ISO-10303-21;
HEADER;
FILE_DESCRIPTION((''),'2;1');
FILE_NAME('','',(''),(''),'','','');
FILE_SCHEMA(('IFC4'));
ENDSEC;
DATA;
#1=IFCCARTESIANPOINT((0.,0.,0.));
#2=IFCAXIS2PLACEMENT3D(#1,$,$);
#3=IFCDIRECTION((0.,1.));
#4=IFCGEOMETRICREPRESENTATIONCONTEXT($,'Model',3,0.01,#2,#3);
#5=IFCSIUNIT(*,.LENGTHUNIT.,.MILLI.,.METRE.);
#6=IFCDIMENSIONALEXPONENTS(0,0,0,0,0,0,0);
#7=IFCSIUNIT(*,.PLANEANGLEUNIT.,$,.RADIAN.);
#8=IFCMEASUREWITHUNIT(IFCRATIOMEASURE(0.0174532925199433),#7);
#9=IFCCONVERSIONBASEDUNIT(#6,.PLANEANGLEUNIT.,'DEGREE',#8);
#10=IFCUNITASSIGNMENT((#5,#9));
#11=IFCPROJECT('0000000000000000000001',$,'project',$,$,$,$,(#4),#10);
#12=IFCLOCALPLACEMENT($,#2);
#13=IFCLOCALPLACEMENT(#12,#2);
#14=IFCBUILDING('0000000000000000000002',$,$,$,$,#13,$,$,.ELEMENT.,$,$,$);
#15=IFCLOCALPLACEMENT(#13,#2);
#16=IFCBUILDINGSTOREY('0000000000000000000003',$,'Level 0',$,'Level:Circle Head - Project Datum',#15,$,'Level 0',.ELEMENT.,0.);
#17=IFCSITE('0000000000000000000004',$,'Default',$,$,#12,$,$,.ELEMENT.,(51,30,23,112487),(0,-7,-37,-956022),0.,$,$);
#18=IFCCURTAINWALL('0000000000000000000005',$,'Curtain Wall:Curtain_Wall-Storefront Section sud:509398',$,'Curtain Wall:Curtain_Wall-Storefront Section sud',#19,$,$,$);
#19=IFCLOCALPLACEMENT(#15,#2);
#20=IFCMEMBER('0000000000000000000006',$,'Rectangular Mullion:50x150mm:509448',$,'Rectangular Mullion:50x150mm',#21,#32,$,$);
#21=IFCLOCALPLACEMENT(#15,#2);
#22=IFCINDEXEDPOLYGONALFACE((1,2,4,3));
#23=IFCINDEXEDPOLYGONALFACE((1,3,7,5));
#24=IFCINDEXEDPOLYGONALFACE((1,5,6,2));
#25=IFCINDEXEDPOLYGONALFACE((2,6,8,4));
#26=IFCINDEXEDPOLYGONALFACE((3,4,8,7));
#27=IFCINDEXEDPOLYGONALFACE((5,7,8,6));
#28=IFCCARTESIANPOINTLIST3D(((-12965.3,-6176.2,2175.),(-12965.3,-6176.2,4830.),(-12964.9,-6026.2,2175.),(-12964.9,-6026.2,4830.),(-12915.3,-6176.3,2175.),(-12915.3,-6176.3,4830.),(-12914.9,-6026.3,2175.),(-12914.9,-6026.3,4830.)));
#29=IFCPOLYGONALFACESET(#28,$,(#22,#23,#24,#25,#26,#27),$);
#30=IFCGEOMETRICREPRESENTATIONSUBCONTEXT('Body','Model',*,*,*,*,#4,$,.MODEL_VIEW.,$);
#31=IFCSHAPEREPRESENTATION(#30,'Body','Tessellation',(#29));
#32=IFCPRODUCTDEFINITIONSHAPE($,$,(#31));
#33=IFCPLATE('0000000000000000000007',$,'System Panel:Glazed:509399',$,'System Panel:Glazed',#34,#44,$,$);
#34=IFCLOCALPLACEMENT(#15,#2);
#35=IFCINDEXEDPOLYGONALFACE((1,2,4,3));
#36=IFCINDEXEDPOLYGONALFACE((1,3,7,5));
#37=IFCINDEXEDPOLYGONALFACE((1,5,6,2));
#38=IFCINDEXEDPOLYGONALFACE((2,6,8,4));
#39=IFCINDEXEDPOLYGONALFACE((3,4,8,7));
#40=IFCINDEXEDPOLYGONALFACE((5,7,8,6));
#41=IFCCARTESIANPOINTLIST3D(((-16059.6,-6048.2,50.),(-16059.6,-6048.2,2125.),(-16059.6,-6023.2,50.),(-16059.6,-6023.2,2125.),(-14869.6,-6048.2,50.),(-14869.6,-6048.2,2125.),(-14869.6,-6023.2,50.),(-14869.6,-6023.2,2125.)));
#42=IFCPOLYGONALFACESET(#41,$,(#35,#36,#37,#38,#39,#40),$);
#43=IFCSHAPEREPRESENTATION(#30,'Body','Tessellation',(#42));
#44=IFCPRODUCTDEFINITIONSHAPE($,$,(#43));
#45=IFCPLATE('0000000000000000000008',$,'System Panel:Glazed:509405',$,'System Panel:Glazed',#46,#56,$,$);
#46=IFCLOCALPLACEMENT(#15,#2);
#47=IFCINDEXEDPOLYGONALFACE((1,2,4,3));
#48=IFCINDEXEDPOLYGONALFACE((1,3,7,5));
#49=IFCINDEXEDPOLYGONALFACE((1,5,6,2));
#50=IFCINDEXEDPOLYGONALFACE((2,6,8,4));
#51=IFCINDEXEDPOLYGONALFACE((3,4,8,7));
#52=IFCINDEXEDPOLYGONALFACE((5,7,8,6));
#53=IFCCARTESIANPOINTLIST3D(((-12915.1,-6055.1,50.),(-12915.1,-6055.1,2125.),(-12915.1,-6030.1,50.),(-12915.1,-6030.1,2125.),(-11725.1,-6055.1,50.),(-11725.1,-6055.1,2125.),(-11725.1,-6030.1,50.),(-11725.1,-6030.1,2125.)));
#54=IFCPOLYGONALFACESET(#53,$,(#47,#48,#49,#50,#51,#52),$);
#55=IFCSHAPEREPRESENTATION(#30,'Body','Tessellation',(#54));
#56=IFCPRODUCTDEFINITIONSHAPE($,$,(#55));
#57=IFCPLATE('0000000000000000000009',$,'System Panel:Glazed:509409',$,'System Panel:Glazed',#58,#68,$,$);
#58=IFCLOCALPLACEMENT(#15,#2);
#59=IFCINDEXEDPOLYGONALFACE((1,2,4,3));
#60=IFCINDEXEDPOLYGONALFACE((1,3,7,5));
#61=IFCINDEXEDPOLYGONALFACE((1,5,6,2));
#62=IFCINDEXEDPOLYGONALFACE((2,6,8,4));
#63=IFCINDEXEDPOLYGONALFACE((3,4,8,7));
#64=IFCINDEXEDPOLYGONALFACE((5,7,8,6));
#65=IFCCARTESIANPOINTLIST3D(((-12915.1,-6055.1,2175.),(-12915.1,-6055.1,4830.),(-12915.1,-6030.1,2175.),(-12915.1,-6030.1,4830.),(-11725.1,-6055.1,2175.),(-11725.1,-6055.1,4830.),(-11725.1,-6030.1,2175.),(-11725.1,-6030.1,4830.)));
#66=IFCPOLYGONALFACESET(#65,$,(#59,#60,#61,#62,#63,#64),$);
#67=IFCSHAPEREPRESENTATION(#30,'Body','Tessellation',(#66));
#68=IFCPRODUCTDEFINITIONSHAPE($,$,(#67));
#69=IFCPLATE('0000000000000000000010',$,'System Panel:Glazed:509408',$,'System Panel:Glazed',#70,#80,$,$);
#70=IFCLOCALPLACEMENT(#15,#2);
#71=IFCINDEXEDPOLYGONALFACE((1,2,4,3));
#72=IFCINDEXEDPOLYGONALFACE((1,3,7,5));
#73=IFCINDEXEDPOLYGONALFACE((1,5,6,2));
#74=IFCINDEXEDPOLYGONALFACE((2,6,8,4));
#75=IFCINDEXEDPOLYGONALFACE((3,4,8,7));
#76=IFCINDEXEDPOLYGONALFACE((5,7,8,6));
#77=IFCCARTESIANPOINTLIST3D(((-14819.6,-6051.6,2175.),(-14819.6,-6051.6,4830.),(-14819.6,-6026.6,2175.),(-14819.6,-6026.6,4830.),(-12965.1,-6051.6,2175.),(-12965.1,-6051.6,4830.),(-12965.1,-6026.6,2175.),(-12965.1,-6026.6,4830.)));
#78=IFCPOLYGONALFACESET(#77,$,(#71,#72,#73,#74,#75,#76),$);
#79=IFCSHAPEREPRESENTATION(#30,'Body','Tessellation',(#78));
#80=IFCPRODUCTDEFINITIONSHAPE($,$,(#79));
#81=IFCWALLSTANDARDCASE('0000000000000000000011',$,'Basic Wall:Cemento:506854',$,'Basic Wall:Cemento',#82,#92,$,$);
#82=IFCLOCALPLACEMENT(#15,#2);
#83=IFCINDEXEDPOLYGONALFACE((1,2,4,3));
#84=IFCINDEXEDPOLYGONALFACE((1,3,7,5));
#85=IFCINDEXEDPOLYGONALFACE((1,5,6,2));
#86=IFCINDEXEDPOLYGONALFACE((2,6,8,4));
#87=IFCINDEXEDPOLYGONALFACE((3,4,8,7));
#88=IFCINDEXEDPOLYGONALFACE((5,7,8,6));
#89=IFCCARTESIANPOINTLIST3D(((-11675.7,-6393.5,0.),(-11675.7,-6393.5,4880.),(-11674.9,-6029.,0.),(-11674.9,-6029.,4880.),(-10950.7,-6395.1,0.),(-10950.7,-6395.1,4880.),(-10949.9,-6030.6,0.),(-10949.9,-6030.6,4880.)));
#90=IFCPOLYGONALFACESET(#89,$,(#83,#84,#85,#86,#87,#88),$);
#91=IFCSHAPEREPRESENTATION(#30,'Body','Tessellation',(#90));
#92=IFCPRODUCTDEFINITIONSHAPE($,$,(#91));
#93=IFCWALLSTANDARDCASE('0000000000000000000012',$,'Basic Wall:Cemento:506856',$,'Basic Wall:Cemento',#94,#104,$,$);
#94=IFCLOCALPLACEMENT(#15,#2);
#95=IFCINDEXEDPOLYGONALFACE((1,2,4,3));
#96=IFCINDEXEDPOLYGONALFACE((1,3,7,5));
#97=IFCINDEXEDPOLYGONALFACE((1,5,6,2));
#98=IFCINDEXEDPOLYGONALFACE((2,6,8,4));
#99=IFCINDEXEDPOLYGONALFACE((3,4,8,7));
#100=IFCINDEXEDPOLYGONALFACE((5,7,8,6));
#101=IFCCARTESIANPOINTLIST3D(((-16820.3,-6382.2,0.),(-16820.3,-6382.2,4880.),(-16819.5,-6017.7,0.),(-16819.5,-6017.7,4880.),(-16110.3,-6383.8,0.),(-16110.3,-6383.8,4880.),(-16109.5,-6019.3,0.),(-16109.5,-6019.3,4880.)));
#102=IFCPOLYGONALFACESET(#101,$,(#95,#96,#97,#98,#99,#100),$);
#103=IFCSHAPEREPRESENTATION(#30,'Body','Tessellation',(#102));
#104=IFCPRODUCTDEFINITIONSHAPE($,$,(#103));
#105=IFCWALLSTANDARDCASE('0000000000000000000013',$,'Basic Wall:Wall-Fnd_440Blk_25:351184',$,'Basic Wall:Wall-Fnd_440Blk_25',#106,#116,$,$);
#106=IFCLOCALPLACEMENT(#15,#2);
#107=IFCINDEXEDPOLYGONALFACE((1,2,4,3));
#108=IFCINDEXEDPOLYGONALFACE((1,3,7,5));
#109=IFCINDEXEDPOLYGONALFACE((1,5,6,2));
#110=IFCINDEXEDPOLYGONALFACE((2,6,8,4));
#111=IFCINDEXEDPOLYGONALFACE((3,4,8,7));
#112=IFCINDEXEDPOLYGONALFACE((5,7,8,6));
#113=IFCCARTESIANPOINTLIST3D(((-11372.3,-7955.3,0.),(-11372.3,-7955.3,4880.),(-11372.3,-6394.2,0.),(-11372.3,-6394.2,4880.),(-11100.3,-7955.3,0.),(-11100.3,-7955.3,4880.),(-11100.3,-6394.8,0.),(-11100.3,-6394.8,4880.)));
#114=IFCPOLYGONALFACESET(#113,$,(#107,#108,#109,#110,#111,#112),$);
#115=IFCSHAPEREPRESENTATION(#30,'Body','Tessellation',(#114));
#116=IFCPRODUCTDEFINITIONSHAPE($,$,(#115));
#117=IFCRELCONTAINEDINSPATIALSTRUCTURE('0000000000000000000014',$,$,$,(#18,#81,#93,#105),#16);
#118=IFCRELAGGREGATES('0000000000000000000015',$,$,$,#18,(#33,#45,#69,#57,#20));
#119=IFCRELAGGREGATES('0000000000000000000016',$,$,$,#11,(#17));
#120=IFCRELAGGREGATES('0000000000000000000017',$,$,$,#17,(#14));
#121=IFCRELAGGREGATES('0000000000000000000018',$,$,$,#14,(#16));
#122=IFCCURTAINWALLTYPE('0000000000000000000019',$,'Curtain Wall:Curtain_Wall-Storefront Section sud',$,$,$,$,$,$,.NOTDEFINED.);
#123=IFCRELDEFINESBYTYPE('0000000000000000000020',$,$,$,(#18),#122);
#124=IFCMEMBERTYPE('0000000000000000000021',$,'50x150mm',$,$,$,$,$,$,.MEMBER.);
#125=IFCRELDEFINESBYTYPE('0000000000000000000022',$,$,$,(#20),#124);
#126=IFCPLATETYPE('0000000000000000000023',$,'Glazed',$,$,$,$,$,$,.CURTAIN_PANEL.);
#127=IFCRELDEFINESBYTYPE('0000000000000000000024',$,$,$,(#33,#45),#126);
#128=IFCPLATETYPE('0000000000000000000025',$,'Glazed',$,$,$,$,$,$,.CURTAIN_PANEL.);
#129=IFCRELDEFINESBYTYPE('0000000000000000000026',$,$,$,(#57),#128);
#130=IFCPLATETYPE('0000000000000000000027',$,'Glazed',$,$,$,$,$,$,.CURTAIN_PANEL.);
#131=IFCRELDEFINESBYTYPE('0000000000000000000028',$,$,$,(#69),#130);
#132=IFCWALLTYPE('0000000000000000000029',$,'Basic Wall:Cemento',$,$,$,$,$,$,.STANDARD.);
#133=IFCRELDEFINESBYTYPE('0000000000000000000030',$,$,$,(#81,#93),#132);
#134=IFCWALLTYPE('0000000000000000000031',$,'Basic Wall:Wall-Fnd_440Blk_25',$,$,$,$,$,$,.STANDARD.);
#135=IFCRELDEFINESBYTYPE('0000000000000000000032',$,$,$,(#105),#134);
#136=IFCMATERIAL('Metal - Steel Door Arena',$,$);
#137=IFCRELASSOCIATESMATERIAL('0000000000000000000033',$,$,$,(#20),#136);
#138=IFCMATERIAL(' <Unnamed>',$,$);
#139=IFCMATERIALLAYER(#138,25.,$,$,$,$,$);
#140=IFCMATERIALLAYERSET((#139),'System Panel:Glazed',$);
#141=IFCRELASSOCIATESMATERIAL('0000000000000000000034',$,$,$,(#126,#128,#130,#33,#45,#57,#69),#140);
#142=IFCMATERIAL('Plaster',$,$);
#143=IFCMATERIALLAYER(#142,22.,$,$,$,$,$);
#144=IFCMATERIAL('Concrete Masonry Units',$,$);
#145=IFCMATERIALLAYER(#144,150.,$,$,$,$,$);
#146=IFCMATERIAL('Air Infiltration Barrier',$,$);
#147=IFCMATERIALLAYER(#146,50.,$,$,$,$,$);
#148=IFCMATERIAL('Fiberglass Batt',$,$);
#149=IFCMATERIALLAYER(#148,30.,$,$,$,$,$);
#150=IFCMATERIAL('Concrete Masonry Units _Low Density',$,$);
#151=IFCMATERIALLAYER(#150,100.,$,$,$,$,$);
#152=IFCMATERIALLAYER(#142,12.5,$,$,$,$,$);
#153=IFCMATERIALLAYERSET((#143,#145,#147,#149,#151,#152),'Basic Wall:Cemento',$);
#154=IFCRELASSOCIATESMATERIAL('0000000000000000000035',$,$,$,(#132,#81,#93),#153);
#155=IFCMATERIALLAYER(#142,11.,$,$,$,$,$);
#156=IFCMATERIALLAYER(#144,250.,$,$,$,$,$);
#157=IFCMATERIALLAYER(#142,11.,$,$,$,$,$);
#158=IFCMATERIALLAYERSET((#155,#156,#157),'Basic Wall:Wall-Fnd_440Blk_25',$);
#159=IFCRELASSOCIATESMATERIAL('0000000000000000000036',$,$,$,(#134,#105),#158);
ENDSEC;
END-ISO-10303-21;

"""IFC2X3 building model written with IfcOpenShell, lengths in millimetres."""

from ifc_helpers import new_model, entity, si_unit, converted_unit, direction, frame, frame_2d, origin, origin_2d_with_axis, place, context, subcontext, project, spatial, polyline, rectangle, outline, extrude, clip, bounded_halfspace, source, transform, mapped, material, layer, layer_set, layer_usage, type_object, type_shapes, element, aggregate, save


model = new_model("IFC2X3")

# Units and contexts
model_context = context("Model", 3, precision=0.01, world=origin(), true_north=direction((0.0, 1.0)))
body_context = subcontext(model_context, "Body", "Model", "MODEL_VIEW")
ifc_project = project(units=[si_unit("LENGTHUNIT", "METRE", prefix="MILLI"), converted_unit("PLANEANGLEUNIT", "DEGREE", entity("IfcRatioMeasure", 0.0174532925199433), si_unit("PLANEANGLEUNIT", "RADIAN"), dimensions=[0, 0, 0, 0, 0, 0, 0])], contexts=[model_context])

# Site, building, storey
site_placement = place(None, origin())
site = spatial("IfcSite", under=ifc_project, at=site_placement, Name="Default", CompositionType="ELEMENT", RefLatitude=(51, 30, 23, 112487), RefLongitude=(0, -7, -37, -956022), RefElevation=0.0)
building_placement = place(site_placement, origin())
building = spatial("IfcBuilding", under=site, at=building_placement, CompositionType="ELEMENT")
storey_placement = place(building_placement, origin())
storey = spatial("IfcBuildingStorey", under=building, at=storey_placement, Name="Level 0", ObjectType="Level:Circle Head - Project Datum", LongName="Level 0", CompositionType="ELEMENT", Elevation=0.0)

# Curtain wall, member, plates
curtain_wall_type = type_object("IfcCurtainWallType", Name="Curtain Wall:Curtain_Wall-Storefront Section sud", PredefinedType="NOTDEFINED")
curtain_wall_placement = place(storey_placement, origin())
curtain_wall = element("IfcCurtainWall", 1, at=curtain_wall_placement, inside=storey, type_object=curtain_wall_type, Name="Curtain Wall:Curtain_Wall-Storefront Section sud:509398", ObjectType="Curtain Wall:Curtain_Wall-Storefront Section sud")
ifc_material_1 = material(Name="Metal - Steel Door Arena")
member_type_1 = type_object("IfcMemberType", Name="50x150mm", PredefinedType="MEMBER")
shared_shape_1 = source(origin(), body_context, "Body", "SweptSolid", [
    extrude(rectangle(XDim=150.0, YDim=50.0, at=origin_2d_with_axis()), frame((0.0, 0.0, -2655.0), z_axis=(0.0, 0.0, 1.0), x_axis=(0.0, -1.0, 0.0)), (0.0, 0.0, 1.0), 2655.0),
])
type_shapes(member_type_1, [shared_shape_1])
member_1_placement = place(storey_placement, frame((-12940.1, -6101.2, 2175.0), z_axis=(0.0, 0.0, -1.0), x_axis=(0.999998, -0.002199, 0.0)))
member_1 = element("IfcMember", 2, at=member_1_placement, type_object=member_type_1, material=ifc_material_1, Name="Rectangular Mullion:50x150mm:509448", ObjectType="Rectangular Mullion:50x150mm", context=body_context, shape_type="MappedRepresentation", body=[
    mapped(shared_shape_1, transform((0.0, 0.0, 0.0), scale=1.0)),
])
ifc_material_2 = material(Name=" <Unnamed>")
ifc_layer_1 = layer(ifc_material_2, 25.0)
ifc_layer_set_1 = layer_set([ifc_layer_1], Name="System Panel:Glazed")
ifc_layer_usage_1 = layer_usage(ifc_layer_set_1, "AXIS3", "POSITIVE", 0.2)
plate_type_1 = type_object("IfcPlateType", Name="Glazed", PredefinedType="CURTAIN_PANEL", material=ifc_layer_set_1)
shared_shape_2 = source(origin(), body_context, "Body", "SweptSolid", [
    extrude(rectangle(XDim=25.0, YDim=1190.0, at=origin_2d_with_axis()), frame((0.0, 60.0, 0.0), z_axis=(0.0, 0.0, 1.0), x_axis=(0.0, 1.0, 0.0)), (0.0, 0.0, 1.0), 2075.0),
])
type_shapes(plate_type_1, [shared_shape_2])
plate_1_placement = place(curtain_wall_placement, frame((-15464.6, -6095.7, 50.0)))
plate_1 = element("IfcPlate", 3, at=plate_1_placement, type_object=plate_type_1, material=ifc_layer_usage_1, Name="System Panel:Glazed:509399", ObjectType="System Panel:Glazed", context=body_context, shape_type="MappedRepresentation", body=[
    mapped(shared_shape_2, transform((0.0, 0.0, 0.0), scale=1.0)),
])
ifc_layer_usage_2 = layer_usage(ifc_layer_set_1, "AXIS3", "POSITIVE", 0.2)
plate_2_placement = place(curtain_wall_placement, frame((-12320.1, -6102.6, 50.0)))
plate_2 = element("IfcPlate", 4, at=plate_2_placement, type_object=plate_type_1, material=ifc_layer_usage_2, Name="System Panel:Glazed:509405", ObjectType="System Panel:Glazed", context=body_context, shape_type="MappedRepresentation", body=[
    mapped(shared_shape_2, transform((0.0, 0.0, 0.0), scale=1.0)),
])
ifc_layer_usage_3 = layer_usage(ifc_layer_set_1, "AXIS3", "POSITIVE", 0.2)
plate_type_2 = type_object("IfcPlateType", Name="Glazed", PredefinedType="CURTAIN_PANEL", material=ifc_layer_set_1)
shared_shape_3 = source(origin(), body_context, "Body", "SweptSolid", [
    extrude(rectangle(XDim=25.0, YDim=1190.0, at=frame_2d((0.0, 0.0), x_axis=(1.0, 0.0))), frame((0.0, 60.0, 0.0), z_axis=(0.0, 0.0, 1.0), x_axis=(0.0, 1.0, 0.0)), (0.0, 0.0, 1.0), 2655.0),
])
type_shapes(plate_type_2, [shared_shape_3])
plate_3_placement = place(curtain_wall_placement, frame((-12320.1, -6102.6, 2175.0)))
plate_3 = element("IfcPlate", 5, at=plate_3_placement, type_object=plate_type_2, material=ifc_layer_usage_3, Name="System Panel:Glazed:509409", ObjectType="System Panel:Glazed", context=body_context, shape_type="MappedRepresentation", body=[
    mapped(shared_shape_3, transform((0.0, 0.0, 0.0), scale=1.0)),
])
ifc_layer_usage_4 = layer_usage(ifc_layer_set_1, "AXIS3", "POSITIVE", 0.2)
plate_type_3 = type_object("IfcPlateType", Name="Glazed", PredefinedType="CURTAIN_PANEL", material=ifc_layer_set_1)
shared_shape_4 = source(origin(), body_context, "Body", "SweptSolid", [
    extrude(rectangle(XDim=25.0, YDim=1854.5, at=frame_2d((0.0, 0.0), x_axis=(1.0, 0.0))), frame((0.0, 60.0, 0.0), z_axis=(0.0, 0.0, 1.0), x_axis=(0.0, 1.0, 0.0)), (0.0, 0.0, 1.0), 2655.0),
])
type_shapes(plate_type_3, [shared_shape_4])
plate_4_placement = place(curtain_wall_placement, frame((-13892.4, -6099.1, 2175.0)))
plate_4 = element("IfcPlate", 6, at=plate_4_placement, type_object=plate_type_3, material=ifc_layer_usage_4, Name="System Panel:Glazed:509408", ObjectType="System Panel:Glazed", context=body_context, shape_type="MappedRepresentation", body=[
    mapped(shared_shape_4, transform((0.0, 0.0, 0.0), scale=1.0)),
])
aggregate(curtain_wall, [plate_1, plate_2, plate_4, plate_3, member_1])

# Walls
ifc_material_3 = material(Name="Plaster")
ifc_layer_2 = layer(ifc_material_3, 22.0)
ifc_material_4 = material(Name="Concrete Masonry Units")
ifc_layer_3 = layer(ifc_material_4, 150.0)
ifc_material_5 = material(Name="Air Infiltration Barrier")
ifc_layer_4 = layer(ifc_material_5, 50.0)
ifc_material_6 = material(Name="Fiberglass Batt")
ifc_layer_5 = layer(ifc_material_6, 30.0)
ifc_material_7 = material(Name="Concrete Masonry Units _Low Density")
ifc_layer_6 = layer(ifc_material_7, 100.0)
ifc_layer_7 = layer(ifc_material_3, 12.5)
ifc_layer_set_2 = layer_set([ifc_layer_2, ifc_layer_3, ifc_layer_4, ifc_layer_5, ifc_layer_6, ifc_layer_7], Name="Basic Wall:Cemento")
ifc_layer_usage_5 = layer_usage(ifc_layer_set_2, "AXIS2", "NEGATIVE", 182.2)
wall_type_1 = type_object("IfcWallType", Name="Basic Wall:Cemento", PredefinedType="STANDARD", material=ifc_layer_set_2)
wall_1_placement = place(storey_placement, frame((-10950.3, -6212.9, 0.0), z_axis=(0.0, 0.0, 1.0), x_axis=(-0.999998, 0.002199, 0.0)))
element("IfcWallStandardCase", 7, at=wall_1_placement, inside=storey, type_object=wall_type_1, material=ifc_layer_usage_5, Name="Basic Wall:Cemento:506854", ObjectType="Basic Wall:Cemento", context=body_context, shape_type="SweptSolid", body=[
    extrude(rectangle(XDim=725.0, YDim=364.5, at=frame_2d((362.5, 0.0), x_axis=(-1.0, 0.0))), origin(), (0.0, 0.0, 1.0), 4880.0),
])
ifc_layer_usage_6 = layer_usage(ifc_layer_set_2, "AXIS2", "NEGATIVE", 182.2)
wall_2_placement = place(storey_placement, frame((-16109.9, -6201.5, 0.0), z_axis=(0.0, 0.0, 1.0), x_axis=(-0.999998, 0.002199, 0.0)))
element("IfcWallStandardCase", 8, at=wall_2_placement, inside=storey, type_object=wall_type_1, material=ifc_layer_usage_6, Name="Basic Wall:Cemento:506856", ObjectType="Basic Wall:Cemento", context=body_context, shape_type="SweptSolid", body=[
    extrude(rectangle(XDim=710.0, YDim=364.5, at=frame_2d((355.0, 0.0), x_axis=(-1.0, 0.0))), origin(), (0.0, 0.0, 1.0), 4880.0),
])
ifc_layer_8 = layer(ifc_material_3, 11.0)
ifc_layer_9 = layer(ifc_material_4, 250.0)
ifc_layer_10 = layer(ifc_material_3, 11.0)
ifc_layer_set_3 = layer_set([ifc_layer_8, ifc_layer_9, ifc_layer_10], Name="Basic Wall:Wall-Fnd_440Blk_25")
ifc_layer_usage_7 = layer_usage(ifc_layer_set_3, "AXIS2", "NEGATIVE", 136.0)
wall_type_2 = type_object("IfcWallType", Name="Basic Wall:Wall-Fnd_440Blk_25", PredefinedType="STANDARD", material=ifc_layer_set_3)
wall_3_placement = place(storey_placement, frame((-11236.3, -7955.3, 0.0), z_axis=(0.0, 0.0, 1.0), x_axis=(0.0, 1.0, 0.0)))
element("IfcWallStandardCase", 9, at=wall_3_placement, inside=storey, type_object=wall_type_2, material=ifc_layer_usage_7, Name="Basic Wall:Wall-Fnd_440Blk_25:351184", ObjectType="Basic Wall:Wall-Fnd_440Blk_25", context=body_context, shape_type="Clipping", body=[
    clip(extrude(outline(polyline([(1560.5, -136.0), (1561.1, 136.0), (0.0, 136.0), (0.0, -136.0), (1560.5, -136.0)])), origin(), (0.0, 0.0, 1.0), 4880.0), bounded_halfspace(frame((0.0, -136.0, 4880.0), z_axis=(0.0, 0.0, -1.0), x_axis=(0.0, -1.0, 0.0)), True, frame((0.0, -136.0, 4880.0)), polyline([(0.0, 0.0), (1560.5, 0.0), (1561.1, 272.0), (1557.5, 272.0), (0.0, 272.0), (0.0, 0.0)]))),
])

save(model, "model.ifc")
